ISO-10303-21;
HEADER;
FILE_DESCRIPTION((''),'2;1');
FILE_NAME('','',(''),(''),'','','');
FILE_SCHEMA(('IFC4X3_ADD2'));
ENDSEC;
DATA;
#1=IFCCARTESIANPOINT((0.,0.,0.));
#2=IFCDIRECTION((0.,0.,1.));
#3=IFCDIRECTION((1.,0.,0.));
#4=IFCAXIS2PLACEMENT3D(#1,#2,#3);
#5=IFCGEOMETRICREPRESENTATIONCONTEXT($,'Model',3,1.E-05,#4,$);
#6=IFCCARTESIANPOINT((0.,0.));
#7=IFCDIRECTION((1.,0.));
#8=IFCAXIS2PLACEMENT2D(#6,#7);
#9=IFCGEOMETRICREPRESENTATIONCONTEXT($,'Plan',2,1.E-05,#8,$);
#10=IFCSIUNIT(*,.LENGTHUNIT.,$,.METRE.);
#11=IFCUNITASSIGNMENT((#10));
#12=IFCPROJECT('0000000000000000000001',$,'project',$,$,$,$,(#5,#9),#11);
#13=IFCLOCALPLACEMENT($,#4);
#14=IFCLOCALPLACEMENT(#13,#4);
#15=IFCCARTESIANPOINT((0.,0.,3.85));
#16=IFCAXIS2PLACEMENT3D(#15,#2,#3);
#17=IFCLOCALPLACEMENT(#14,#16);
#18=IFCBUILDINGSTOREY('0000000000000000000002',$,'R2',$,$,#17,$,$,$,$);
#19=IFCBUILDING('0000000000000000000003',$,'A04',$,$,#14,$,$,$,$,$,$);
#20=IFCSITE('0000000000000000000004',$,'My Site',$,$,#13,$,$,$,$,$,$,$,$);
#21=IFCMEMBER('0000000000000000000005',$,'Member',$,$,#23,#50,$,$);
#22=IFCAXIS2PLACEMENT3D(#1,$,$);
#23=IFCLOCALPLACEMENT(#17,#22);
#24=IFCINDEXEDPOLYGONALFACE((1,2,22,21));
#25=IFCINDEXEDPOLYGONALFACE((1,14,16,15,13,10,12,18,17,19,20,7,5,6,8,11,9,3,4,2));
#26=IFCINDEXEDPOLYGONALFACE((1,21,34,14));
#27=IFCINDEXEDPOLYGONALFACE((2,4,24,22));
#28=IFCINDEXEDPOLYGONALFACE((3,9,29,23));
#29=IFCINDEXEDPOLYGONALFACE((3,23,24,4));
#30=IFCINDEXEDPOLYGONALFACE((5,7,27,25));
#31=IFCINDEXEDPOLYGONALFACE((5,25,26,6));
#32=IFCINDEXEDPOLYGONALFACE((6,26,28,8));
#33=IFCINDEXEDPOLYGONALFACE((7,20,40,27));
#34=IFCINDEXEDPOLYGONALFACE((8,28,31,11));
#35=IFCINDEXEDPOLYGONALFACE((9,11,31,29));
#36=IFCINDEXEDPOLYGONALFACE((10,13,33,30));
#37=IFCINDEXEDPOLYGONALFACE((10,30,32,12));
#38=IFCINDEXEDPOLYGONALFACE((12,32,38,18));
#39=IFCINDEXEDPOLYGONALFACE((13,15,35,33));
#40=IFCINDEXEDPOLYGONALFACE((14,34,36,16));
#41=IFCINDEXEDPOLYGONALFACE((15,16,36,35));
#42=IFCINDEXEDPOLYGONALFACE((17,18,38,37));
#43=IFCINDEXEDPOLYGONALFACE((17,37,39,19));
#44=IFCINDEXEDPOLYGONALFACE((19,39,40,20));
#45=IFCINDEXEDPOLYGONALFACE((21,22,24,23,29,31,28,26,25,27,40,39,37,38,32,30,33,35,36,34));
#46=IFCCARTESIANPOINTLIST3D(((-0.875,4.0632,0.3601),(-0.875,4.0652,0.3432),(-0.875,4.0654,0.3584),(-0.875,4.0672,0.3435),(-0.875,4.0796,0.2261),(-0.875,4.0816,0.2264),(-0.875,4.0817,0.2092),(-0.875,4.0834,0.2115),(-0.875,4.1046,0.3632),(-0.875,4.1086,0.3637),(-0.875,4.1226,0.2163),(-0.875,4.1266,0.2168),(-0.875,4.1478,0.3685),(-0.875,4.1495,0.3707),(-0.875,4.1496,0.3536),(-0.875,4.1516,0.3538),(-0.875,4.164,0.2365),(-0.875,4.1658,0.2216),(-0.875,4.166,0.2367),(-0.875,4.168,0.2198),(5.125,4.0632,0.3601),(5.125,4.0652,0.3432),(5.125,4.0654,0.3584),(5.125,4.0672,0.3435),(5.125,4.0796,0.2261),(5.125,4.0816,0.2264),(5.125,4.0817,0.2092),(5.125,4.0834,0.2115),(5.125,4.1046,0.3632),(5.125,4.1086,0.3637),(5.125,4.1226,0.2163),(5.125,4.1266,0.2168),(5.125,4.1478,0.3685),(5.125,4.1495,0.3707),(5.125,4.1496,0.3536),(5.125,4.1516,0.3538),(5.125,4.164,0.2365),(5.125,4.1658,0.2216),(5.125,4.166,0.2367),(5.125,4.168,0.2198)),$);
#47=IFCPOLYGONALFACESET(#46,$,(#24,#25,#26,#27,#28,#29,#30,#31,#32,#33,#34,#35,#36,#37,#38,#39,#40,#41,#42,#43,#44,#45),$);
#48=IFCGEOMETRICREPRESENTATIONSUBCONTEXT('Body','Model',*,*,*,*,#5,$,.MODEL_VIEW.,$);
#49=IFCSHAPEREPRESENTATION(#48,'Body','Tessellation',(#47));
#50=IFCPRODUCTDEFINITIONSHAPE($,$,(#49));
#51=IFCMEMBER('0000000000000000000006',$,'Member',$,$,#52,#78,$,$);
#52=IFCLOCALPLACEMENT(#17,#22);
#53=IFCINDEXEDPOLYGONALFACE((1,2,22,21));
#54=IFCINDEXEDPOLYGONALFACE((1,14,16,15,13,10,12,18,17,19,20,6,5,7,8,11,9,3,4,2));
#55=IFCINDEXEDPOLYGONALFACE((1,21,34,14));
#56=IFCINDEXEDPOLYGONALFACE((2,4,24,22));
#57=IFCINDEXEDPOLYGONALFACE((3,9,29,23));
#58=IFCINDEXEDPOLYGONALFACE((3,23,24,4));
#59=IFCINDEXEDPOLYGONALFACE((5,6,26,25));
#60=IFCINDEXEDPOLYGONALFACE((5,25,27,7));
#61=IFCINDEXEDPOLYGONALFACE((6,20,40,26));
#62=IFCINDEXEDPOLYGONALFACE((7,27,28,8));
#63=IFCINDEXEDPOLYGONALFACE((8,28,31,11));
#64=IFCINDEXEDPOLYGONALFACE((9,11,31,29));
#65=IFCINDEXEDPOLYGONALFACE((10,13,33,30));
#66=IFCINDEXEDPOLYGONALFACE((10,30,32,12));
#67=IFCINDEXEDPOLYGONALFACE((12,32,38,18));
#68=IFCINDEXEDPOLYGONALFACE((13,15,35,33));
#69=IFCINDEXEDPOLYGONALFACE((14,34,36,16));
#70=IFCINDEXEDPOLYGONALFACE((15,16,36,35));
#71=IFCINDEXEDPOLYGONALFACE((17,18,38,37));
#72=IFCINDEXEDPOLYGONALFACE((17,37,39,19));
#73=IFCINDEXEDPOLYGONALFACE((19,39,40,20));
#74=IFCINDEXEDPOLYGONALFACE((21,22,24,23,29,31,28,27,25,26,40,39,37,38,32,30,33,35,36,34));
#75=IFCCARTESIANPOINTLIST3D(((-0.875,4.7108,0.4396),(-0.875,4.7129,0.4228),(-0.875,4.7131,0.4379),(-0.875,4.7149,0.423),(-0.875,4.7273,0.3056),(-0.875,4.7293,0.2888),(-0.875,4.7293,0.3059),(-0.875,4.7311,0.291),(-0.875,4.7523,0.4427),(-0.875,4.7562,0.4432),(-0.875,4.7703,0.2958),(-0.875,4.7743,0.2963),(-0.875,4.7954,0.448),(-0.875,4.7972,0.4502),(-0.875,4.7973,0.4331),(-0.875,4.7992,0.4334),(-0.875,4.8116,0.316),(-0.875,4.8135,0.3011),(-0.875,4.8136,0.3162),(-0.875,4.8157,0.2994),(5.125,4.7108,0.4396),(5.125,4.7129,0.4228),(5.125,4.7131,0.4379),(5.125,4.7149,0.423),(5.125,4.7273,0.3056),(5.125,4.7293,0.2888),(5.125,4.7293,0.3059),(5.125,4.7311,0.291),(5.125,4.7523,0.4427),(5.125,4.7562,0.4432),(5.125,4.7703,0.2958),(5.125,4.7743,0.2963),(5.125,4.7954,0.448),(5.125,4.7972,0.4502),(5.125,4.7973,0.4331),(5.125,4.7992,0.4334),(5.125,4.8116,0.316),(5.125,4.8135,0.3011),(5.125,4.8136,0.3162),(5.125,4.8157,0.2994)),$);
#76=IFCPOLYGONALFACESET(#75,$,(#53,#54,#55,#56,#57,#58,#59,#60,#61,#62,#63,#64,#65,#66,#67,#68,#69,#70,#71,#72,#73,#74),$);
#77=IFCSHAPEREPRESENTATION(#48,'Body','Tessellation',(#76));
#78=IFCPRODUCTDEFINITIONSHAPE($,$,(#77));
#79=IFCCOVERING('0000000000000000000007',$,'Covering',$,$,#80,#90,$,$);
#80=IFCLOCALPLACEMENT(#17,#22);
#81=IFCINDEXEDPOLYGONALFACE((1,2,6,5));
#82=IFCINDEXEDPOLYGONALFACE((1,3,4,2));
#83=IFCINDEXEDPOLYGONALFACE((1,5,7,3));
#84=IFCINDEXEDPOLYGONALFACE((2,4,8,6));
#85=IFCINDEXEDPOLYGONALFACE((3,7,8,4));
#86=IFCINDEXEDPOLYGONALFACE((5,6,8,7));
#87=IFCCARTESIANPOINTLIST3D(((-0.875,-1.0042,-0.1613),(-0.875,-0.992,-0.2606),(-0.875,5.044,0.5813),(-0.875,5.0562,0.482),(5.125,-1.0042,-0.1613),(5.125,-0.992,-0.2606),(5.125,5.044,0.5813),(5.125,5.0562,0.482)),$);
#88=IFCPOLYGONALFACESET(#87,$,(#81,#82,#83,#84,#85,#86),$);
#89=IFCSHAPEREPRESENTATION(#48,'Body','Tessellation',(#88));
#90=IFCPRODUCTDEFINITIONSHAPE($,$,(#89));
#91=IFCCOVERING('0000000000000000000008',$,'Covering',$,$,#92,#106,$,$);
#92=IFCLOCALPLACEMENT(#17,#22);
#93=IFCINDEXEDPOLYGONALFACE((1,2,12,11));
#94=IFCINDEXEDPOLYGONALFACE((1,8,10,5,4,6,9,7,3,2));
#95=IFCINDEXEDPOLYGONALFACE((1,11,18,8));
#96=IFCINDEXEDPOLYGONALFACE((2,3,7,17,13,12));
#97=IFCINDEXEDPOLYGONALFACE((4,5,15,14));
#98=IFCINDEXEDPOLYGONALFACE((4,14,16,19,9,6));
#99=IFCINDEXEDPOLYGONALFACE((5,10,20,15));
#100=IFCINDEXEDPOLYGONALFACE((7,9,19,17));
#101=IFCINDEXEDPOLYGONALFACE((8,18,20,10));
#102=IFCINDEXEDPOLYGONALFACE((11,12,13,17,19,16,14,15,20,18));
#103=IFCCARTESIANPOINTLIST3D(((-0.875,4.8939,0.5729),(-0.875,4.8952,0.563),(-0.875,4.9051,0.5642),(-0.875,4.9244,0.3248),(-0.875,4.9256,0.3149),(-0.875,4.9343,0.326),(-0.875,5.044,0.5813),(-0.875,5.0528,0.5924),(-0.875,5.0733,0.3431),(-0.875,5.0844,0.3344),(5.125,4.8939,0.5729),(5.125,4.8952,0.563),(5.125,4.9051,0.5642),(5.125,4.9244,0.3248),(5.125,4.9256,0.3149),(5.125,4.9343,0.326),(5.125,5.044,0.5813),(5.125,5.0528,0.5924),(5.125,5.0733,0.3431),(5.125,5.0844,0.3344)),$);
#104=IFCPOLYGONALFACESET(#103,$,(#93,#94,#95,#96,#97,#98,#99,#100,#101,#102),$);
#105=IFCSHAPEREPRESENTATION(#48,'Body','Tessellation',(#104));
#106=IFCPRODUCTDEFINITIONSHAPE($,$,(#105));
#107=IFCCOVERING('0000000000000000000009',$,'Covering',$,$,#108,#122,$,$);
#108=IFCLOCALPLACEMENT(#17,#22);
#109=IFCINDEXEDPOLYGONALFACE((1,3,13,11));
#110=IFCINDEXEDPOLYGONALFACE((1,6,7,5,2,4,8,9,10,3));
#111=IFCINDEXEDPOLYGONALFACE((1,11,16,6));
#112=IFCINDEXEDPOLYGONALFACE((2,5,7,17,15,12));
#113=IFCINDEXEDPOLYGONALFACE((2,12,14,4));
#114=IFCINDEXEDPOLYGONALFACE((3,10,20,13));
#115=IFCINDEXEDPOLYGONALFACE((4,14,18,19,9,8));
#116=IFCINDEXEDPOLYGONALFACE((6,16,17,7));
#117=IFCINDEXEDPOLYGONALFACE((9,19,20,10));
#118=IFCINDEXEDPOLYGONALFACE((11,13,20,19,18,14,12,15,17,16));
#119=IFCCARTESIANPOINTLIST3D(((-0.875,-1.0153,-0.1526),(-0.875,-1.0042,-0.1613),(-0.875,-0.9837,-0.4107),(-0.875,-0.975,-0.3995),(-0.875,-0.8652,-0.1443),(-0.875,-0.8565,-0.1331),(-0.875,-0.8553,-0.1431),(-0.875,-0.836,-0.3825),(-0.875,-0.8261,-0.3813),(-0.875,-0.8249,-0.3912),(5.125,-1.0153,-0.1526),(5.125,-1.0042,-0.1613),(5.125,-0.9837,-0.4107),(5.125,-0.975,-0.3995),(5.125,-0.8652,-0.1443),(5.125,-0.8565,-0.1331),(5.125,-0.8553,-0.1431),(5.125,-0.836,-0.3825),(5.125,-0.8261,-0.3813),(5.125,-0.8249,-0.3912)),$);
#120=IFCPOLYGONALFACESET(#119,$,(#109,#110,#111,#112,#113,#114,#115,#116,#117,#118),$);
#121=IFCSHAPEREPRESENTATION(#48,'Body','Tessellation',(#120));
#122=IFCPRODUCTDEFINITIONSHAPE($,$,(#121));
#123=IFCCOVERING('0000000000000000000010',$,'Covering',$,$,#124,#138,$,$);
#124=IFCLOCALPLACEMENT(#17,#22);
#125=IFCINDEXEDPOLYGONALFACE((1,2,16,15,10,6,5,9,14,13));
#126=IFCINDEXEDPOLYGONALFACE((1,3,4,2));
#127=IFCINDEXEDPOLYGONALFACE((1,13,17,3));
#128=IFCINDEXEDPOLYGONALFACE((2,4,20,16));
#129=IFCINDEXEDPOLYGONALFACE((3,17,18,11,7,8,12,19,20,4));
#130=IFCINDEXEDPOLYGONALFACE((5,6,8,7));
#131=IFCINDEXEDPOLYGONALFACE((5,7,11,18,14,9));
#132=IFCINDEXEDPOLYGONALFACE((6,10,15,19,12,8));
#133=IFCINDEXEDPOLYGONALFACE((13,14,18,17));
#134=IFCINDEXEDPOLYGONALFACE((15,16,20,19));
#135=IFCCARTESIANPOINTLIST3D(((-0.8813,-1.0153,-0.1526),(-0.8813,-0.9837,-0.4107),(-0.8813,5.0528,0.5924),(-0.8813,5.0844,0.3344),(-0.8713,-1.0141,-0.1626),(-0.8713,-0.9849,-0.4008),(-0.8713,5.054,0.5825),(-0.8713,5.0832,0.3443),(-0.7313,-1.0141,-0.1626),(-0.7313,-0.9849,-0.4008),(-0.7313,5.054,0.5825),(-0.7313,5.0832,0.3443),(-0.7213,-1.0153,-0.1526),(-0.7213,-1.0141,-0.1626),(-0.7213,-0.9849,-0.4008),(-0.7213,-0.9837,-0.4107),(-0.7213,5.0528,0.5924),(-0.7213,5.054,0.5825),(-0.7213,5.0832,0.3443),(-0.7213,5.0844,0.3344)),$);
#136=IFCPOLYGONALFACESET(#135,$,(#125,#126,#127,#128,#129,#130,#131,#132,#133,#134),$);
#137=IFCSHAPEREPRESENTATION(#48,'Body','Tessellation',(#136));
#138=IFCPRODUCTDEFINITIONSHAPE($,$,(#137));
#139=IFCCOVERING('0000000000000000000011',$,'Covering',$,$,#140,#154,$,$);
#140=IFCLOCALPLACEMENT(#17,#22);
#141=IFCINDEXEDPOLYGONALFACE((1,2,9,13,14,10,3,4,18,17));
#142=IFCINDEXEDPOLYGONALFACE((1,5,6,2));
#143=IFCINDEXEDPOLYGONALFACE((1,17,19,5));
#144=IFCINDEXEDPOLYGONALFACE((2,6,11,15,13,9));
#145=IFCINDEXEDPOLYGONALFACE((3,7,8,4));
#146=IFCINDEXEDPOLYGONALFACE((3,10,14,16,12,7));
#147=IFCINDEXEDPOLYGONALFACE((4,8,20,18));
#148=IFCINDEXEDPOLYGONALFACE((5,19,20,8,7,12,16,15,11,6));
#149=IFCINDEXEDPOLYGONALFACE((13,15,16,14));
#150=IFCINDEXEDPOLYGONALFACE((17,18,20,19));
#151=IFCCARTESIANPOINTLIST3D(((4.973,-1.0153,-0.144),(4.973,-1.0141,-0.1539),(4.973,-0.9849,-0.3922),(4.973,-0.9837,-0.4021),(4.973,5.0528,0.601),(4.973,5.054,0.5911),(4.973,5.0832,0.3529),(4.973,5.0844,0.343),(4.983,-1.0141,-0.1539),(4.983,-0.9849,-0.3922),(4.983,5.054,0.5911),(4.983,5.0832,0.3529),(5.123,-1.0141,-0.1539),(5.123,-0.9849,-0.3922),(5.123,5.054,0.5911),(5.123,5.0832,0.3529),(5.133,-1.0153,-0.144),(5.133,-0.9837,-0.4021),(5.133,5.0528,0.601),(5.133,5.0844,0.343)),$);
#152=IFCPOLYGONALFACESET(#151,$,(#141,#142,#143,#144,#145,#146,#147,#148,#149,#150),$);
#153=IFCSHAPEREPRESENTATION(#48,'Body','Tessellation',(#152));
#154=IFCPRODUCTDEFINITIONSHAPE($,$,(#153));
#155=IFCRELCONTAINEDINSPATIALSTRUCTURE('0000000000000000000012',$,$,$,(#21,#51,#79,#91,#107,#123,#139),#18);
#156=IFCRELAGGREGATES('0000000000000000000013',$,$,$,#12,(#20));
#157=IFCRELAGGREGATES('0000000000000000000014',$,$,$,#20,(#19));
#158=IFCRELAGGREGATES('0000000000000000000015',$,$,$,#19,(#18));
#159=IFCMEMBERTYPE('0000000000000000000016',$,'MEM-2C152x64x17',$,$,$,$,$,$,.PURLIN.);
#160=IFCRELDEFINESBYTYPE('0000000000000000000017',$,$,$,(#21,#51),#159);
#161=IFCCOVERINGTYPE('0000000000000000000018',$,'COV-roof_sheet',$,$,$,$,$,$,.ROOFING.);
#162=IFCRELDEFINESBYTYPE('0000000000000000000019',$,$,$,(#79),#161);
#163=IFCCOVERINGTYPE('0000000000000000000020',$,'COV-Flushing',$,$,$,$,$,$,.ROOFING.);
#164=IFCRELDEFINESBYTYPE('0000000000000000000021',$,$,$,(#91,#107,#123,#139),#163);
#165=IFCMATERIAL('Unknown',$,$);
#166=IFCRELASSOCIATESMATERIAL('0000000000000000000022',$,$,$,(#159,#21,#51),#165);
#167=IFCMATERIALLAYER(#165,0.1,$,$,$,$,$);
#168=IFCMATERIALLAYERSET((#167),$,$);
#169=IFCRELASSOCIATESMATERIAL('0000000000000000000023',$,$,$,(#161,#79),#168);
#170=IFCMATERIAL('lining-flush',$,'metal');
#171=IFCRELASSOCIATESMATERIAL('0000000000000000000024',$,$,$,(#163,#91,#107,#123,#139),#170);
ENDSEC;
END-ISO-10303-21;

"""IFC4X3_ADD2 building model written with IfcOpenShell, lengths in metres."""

from ifc_helpers import new_model, si_unit, frame, origin_with_axes, origin_2d_with_axis, place, context, subcontext, project, spatial, indexed_curve, c_section, outline, extrude, material, layer, layer_set, layer_usage, material_profile, profile_set, profile_usage, type_object, element, save


model = new_model("IFC4X3_ADD2")

# Units and contexts
model_context = context("Model", 3, precision=1e-05, world=origin_with_axes())
plan_context = context("Plan", 2, precision=1e-05, world=origin_2d_with_axis())
body_context = subcontext(model_context, "Body", "Model", "MODEL_VIEW")
ifc_project = project(units=[si_unit("LENGTHUNIT", "METRE")], contexts=[model_context, plan_context])

# Site, building, storey
site_placement = place(None, origin_with_axes())
site = spatial("IfcSite", under=ifc_project, at=site_placement, Name="My Site")
building_placement = place(site_placement, origin_with_axes())
building = spatial("IfcBuilding", under=site, at=building_placement, Name="A04")
storey_placement = place(building_placement, frame((0.0, 0.0, 3.85), z_axis=(0.0, 0.0, 1.0), x_axis=(1.0, 0.0, 0.0)))
storey = spatial("IfcBuildingStorey", under=building, at=storey_placement, Name="R2")

# Members
ifc_material_1 = material(Name="Unknown")
ifc_material_profile_1 = material_profile(ifc_material_1, outline(indexed_curve([(-0.0435, 0.017), (-0.0435, 0.0), (0.0435, 0.0), (0.0435, 0.017), (0.0415, 0.017), (0.0415, 0.002), (0.002, 0.002), (0.002, 0.15), (0.0415, 0.15), (0.0415, 0.135), (0.0435, 0.135), (0.0435, 0.152), (-0.0435, 0.152), (-0.0435, 0.135), (-0.0415, 0.135), (-0.0415, 0.15), (-0.002, 0.15), (-0.002, 0.002), (-0.0415, 0.002), (-0.0415, 0.017), (-0.0435, 0.017)])))
ifc_profile_set_1 = profile_set([ifc_material_profile_1])
member_type_1 = type_object("IfcMemberType", Name="MEM-2C152x64x17", PredefinedType="PURLIN", material=ifc_profile_set_1)
ifc_profile_usage_1 = profile_usage(ifc_profile_set_1, cardinal=5)
member_1_placement = place(storey_placement, frame((5.125, 4.1249, 0.2145), z_axis=(-1.0, 0.0, 0.0), x_axis=(0.0, -0.992546, -0.121869)))
element("IfcMember", 1, at=member_1_placement, inside=storey, type_object=member_type_1, material=ifc_profile_usage_1, Name="Member", context=body_context, shape_type="SweptSolid", body=[
    extrude(outline(indexed_curve([(-0.0435, 0.017), (-0.0435, 0.0), (0.0435, 0.0), (0.0435, 0.017), (0.0415, 0.017), (0.0415, 0.002), (0.002, 0.002), (0.002, 0.15), (0.0415, 0.15), (0.0415, 0.135), (0.0435, 0.135), (0.0435, 0.152), (-0.0435, 0.152), (-0.0435, 0.135), (-0.0415, 0.135), (-0.0415, 0.15), (-0.002, 0.15), (-0.002, 0.002), (-0.0415, 0.002), (-0.0415, 0.017), (-0.0435, 0.017)])), origin_with_axes(), (0.0, 0.0, 1.0), 6.0),
])
ifc_profile_usage_2 = profile_usage(ifc_profile_set_1, cardinal=5)
member_2_placement = place(storey_placement, frame((5.125, 4.7725, 0.2941), z_axis=(-1.0, 0.0, 0.0), x_axis=(0.0, -0.992546, -0.121869)))
element("IfcMember", 2, at=member_2_placement, inside=storey, type_object=member_type_1, material=ifc_profile_usage_2, Name="Member", context=body_context, shape_type="SweptSolid", body=[
    extrude(outline(indexed_curve([(-0.0435, 0.017), (-0.0435, 0.0), (0.0435, 0.0), (0.0435, 0.017), (0.0415, 0.017), (0.0415, 0.002), (0.002, 0.002), (0.002, 0.15), (0.0415, 0.15), (0.0415, 0.135), (0.0435, 0.135), (0.0435, 0.152), (-0.0435, 0.152), (-0.0435, 0.135), (-0.0415, 0.135), (-0.0415, 0.15), (-0.002, 0.15), (-0.002, 0.002), (-0.0415, 0.002), (-0.0415, 0.017), (-0.0435, 0.017)])), origin_with_axes(), (0.0, 0.0, 1.0), 6.0),
])

# Coverings
ifc_layer = layer(ifc_material_1, 0.1)
ifc_layer_set = layer_set([ifc_layer])
ifc_layer_usage = layer_usage(ifc_layer_set, "AXIS3", "POSITIVE", 0.0)
covering_type_1 = type_object("IfcCoveringType", Name="COV-roof_sheet", PredefinedType="ROOFING", material=ifc_layer_set)
covering_1_placement = place(storey_placement, frame((-0.875, -0.992, -0.2606), z_axis=(0.0, -0.121869, 0.992546), x_axis=(1.0, 0.0, 0.0)))
element("IfcCovering", 3, at=covering_1_placement, inside=storey, type_object=covering_type_1, material=ifc_layer_usage, Name="Covering", context=body_context, shape_type="SweptSolid", body=[
    extrude(outline(indexed_curve([(0.0, 0.0), (6.0, 0.0), (6.0, 6.0937), (0.0, 6.0937), (0.0, 0.0)])), None, (0.0, 0.0, 1.0), 0.1),
])
ifc_material_2 = material(Name="lining-flush", Category="metal")
ifc_material_profile_2 = material_profile(ifc_material_2, c_section(Depth=0.26, Width=0.16, WallThickness=0.01, Girth=0.01))
ifc_profile_set_2 = profile_set([ifc_material_profile_2])
ifc_profile_usage_3 = profile_usage(ifc_profile_set_2, cardinal=5)
covering_type_2 = type_object("IfcCoveringType", Name="COV-Flushing", PredefinedType="ROOFING", material=ifc_profile_set_2)
covering_2_placement = place(storey_placement, frame((5.125, 4.9892, 0.4537), z_axis=(-1.0, 0.0, 0.0), x_axis=(0.0, -0.992546, -0.121869)))
element("IfcCovering", 4, at=covering_2_placement, inside=storey, type_object=covering_type_2, material=ifc_profile_usage_3, Name="Covering", context=body_context, shape_type="SweptSolid", body=[
    extrude(c_section(Depth=0.26, Width=0.16, WallThickness=0.01, Girth=0.01), origin_with_axes(), (0.0, 0.0, 1.0), 6.0),
])
ifc_profile_usage_4 = profile_usage(ifc_profile_set_2, cardinal=5)
covering_3_placement = place(storey_placement, frame((-0.875, -0.9201, -0.2719), z_axis=(1.0, 0.0, 0.0), x_axis=(0.0, 0.992546, 0.121869)))
element("IfcCovering", 5, at=covering_3_placement, inside=storey, type_object=covering_type_2, material=ifc_profile_usage_4, Name="Covering", context=body_context, shape_type="SweptSolid", body=[
    extrude(c_section(Depth=0.26, Width=0.16, WallThickness=0.01, Girth=0.01), origin_with_axes(), (0.0, 0.0, 1.0), 6.0),
])
ifc_profile_usage_5 = profile_usage(ifc_profile_set_2, cardinal=5)
covering_4_placement = place(storey_placement, frame((-0.8013, 5.0686, 0.4634), z_axis=(0.0, -0.992546, -0.121869), x_axis=(1.0, 0.0, 0.0)))
element("IfcCovering", 6, at=covering_4_placement, inside=storey, type_object=covering_type_2, material=ifc_profile_usage_5, Name="Covering", context=body_context, shape_type="SweptSolid", body=[
    extrude(c_section(Depth=0.26, Width=0.16, WallThickness=0.01, Girth=0.01), origin_with_axes(), (0.0, 0.0, 1.0), 6.1137),
])
ifc_profile_usage_6 = profile_usage(ifc_profile_set_2, cardinal=5)
covering_5_placement = place(storey_placement, frame((5.053, -0.9995, -0.2731), z_axis=(0.0, 0.992546, 0.121869), x_axis=(-1.0, 0.0, 0.0)))
element("IfcCovering", 7, at=covering_5_placement, inside=storey, type_object=covering_type_2, material=ifc_profile_usage_6, Name="Covering", context=body_context, shape_type="SweptSolid", body=[
    extrude(c_section(Depth=0.26, Width=0.16, WallThickness=0.01, Girth=0.01), origin_with_axes(), (0.0, 0.0, 1.0), 6.1137),
])

save(model, "model.ifc")
